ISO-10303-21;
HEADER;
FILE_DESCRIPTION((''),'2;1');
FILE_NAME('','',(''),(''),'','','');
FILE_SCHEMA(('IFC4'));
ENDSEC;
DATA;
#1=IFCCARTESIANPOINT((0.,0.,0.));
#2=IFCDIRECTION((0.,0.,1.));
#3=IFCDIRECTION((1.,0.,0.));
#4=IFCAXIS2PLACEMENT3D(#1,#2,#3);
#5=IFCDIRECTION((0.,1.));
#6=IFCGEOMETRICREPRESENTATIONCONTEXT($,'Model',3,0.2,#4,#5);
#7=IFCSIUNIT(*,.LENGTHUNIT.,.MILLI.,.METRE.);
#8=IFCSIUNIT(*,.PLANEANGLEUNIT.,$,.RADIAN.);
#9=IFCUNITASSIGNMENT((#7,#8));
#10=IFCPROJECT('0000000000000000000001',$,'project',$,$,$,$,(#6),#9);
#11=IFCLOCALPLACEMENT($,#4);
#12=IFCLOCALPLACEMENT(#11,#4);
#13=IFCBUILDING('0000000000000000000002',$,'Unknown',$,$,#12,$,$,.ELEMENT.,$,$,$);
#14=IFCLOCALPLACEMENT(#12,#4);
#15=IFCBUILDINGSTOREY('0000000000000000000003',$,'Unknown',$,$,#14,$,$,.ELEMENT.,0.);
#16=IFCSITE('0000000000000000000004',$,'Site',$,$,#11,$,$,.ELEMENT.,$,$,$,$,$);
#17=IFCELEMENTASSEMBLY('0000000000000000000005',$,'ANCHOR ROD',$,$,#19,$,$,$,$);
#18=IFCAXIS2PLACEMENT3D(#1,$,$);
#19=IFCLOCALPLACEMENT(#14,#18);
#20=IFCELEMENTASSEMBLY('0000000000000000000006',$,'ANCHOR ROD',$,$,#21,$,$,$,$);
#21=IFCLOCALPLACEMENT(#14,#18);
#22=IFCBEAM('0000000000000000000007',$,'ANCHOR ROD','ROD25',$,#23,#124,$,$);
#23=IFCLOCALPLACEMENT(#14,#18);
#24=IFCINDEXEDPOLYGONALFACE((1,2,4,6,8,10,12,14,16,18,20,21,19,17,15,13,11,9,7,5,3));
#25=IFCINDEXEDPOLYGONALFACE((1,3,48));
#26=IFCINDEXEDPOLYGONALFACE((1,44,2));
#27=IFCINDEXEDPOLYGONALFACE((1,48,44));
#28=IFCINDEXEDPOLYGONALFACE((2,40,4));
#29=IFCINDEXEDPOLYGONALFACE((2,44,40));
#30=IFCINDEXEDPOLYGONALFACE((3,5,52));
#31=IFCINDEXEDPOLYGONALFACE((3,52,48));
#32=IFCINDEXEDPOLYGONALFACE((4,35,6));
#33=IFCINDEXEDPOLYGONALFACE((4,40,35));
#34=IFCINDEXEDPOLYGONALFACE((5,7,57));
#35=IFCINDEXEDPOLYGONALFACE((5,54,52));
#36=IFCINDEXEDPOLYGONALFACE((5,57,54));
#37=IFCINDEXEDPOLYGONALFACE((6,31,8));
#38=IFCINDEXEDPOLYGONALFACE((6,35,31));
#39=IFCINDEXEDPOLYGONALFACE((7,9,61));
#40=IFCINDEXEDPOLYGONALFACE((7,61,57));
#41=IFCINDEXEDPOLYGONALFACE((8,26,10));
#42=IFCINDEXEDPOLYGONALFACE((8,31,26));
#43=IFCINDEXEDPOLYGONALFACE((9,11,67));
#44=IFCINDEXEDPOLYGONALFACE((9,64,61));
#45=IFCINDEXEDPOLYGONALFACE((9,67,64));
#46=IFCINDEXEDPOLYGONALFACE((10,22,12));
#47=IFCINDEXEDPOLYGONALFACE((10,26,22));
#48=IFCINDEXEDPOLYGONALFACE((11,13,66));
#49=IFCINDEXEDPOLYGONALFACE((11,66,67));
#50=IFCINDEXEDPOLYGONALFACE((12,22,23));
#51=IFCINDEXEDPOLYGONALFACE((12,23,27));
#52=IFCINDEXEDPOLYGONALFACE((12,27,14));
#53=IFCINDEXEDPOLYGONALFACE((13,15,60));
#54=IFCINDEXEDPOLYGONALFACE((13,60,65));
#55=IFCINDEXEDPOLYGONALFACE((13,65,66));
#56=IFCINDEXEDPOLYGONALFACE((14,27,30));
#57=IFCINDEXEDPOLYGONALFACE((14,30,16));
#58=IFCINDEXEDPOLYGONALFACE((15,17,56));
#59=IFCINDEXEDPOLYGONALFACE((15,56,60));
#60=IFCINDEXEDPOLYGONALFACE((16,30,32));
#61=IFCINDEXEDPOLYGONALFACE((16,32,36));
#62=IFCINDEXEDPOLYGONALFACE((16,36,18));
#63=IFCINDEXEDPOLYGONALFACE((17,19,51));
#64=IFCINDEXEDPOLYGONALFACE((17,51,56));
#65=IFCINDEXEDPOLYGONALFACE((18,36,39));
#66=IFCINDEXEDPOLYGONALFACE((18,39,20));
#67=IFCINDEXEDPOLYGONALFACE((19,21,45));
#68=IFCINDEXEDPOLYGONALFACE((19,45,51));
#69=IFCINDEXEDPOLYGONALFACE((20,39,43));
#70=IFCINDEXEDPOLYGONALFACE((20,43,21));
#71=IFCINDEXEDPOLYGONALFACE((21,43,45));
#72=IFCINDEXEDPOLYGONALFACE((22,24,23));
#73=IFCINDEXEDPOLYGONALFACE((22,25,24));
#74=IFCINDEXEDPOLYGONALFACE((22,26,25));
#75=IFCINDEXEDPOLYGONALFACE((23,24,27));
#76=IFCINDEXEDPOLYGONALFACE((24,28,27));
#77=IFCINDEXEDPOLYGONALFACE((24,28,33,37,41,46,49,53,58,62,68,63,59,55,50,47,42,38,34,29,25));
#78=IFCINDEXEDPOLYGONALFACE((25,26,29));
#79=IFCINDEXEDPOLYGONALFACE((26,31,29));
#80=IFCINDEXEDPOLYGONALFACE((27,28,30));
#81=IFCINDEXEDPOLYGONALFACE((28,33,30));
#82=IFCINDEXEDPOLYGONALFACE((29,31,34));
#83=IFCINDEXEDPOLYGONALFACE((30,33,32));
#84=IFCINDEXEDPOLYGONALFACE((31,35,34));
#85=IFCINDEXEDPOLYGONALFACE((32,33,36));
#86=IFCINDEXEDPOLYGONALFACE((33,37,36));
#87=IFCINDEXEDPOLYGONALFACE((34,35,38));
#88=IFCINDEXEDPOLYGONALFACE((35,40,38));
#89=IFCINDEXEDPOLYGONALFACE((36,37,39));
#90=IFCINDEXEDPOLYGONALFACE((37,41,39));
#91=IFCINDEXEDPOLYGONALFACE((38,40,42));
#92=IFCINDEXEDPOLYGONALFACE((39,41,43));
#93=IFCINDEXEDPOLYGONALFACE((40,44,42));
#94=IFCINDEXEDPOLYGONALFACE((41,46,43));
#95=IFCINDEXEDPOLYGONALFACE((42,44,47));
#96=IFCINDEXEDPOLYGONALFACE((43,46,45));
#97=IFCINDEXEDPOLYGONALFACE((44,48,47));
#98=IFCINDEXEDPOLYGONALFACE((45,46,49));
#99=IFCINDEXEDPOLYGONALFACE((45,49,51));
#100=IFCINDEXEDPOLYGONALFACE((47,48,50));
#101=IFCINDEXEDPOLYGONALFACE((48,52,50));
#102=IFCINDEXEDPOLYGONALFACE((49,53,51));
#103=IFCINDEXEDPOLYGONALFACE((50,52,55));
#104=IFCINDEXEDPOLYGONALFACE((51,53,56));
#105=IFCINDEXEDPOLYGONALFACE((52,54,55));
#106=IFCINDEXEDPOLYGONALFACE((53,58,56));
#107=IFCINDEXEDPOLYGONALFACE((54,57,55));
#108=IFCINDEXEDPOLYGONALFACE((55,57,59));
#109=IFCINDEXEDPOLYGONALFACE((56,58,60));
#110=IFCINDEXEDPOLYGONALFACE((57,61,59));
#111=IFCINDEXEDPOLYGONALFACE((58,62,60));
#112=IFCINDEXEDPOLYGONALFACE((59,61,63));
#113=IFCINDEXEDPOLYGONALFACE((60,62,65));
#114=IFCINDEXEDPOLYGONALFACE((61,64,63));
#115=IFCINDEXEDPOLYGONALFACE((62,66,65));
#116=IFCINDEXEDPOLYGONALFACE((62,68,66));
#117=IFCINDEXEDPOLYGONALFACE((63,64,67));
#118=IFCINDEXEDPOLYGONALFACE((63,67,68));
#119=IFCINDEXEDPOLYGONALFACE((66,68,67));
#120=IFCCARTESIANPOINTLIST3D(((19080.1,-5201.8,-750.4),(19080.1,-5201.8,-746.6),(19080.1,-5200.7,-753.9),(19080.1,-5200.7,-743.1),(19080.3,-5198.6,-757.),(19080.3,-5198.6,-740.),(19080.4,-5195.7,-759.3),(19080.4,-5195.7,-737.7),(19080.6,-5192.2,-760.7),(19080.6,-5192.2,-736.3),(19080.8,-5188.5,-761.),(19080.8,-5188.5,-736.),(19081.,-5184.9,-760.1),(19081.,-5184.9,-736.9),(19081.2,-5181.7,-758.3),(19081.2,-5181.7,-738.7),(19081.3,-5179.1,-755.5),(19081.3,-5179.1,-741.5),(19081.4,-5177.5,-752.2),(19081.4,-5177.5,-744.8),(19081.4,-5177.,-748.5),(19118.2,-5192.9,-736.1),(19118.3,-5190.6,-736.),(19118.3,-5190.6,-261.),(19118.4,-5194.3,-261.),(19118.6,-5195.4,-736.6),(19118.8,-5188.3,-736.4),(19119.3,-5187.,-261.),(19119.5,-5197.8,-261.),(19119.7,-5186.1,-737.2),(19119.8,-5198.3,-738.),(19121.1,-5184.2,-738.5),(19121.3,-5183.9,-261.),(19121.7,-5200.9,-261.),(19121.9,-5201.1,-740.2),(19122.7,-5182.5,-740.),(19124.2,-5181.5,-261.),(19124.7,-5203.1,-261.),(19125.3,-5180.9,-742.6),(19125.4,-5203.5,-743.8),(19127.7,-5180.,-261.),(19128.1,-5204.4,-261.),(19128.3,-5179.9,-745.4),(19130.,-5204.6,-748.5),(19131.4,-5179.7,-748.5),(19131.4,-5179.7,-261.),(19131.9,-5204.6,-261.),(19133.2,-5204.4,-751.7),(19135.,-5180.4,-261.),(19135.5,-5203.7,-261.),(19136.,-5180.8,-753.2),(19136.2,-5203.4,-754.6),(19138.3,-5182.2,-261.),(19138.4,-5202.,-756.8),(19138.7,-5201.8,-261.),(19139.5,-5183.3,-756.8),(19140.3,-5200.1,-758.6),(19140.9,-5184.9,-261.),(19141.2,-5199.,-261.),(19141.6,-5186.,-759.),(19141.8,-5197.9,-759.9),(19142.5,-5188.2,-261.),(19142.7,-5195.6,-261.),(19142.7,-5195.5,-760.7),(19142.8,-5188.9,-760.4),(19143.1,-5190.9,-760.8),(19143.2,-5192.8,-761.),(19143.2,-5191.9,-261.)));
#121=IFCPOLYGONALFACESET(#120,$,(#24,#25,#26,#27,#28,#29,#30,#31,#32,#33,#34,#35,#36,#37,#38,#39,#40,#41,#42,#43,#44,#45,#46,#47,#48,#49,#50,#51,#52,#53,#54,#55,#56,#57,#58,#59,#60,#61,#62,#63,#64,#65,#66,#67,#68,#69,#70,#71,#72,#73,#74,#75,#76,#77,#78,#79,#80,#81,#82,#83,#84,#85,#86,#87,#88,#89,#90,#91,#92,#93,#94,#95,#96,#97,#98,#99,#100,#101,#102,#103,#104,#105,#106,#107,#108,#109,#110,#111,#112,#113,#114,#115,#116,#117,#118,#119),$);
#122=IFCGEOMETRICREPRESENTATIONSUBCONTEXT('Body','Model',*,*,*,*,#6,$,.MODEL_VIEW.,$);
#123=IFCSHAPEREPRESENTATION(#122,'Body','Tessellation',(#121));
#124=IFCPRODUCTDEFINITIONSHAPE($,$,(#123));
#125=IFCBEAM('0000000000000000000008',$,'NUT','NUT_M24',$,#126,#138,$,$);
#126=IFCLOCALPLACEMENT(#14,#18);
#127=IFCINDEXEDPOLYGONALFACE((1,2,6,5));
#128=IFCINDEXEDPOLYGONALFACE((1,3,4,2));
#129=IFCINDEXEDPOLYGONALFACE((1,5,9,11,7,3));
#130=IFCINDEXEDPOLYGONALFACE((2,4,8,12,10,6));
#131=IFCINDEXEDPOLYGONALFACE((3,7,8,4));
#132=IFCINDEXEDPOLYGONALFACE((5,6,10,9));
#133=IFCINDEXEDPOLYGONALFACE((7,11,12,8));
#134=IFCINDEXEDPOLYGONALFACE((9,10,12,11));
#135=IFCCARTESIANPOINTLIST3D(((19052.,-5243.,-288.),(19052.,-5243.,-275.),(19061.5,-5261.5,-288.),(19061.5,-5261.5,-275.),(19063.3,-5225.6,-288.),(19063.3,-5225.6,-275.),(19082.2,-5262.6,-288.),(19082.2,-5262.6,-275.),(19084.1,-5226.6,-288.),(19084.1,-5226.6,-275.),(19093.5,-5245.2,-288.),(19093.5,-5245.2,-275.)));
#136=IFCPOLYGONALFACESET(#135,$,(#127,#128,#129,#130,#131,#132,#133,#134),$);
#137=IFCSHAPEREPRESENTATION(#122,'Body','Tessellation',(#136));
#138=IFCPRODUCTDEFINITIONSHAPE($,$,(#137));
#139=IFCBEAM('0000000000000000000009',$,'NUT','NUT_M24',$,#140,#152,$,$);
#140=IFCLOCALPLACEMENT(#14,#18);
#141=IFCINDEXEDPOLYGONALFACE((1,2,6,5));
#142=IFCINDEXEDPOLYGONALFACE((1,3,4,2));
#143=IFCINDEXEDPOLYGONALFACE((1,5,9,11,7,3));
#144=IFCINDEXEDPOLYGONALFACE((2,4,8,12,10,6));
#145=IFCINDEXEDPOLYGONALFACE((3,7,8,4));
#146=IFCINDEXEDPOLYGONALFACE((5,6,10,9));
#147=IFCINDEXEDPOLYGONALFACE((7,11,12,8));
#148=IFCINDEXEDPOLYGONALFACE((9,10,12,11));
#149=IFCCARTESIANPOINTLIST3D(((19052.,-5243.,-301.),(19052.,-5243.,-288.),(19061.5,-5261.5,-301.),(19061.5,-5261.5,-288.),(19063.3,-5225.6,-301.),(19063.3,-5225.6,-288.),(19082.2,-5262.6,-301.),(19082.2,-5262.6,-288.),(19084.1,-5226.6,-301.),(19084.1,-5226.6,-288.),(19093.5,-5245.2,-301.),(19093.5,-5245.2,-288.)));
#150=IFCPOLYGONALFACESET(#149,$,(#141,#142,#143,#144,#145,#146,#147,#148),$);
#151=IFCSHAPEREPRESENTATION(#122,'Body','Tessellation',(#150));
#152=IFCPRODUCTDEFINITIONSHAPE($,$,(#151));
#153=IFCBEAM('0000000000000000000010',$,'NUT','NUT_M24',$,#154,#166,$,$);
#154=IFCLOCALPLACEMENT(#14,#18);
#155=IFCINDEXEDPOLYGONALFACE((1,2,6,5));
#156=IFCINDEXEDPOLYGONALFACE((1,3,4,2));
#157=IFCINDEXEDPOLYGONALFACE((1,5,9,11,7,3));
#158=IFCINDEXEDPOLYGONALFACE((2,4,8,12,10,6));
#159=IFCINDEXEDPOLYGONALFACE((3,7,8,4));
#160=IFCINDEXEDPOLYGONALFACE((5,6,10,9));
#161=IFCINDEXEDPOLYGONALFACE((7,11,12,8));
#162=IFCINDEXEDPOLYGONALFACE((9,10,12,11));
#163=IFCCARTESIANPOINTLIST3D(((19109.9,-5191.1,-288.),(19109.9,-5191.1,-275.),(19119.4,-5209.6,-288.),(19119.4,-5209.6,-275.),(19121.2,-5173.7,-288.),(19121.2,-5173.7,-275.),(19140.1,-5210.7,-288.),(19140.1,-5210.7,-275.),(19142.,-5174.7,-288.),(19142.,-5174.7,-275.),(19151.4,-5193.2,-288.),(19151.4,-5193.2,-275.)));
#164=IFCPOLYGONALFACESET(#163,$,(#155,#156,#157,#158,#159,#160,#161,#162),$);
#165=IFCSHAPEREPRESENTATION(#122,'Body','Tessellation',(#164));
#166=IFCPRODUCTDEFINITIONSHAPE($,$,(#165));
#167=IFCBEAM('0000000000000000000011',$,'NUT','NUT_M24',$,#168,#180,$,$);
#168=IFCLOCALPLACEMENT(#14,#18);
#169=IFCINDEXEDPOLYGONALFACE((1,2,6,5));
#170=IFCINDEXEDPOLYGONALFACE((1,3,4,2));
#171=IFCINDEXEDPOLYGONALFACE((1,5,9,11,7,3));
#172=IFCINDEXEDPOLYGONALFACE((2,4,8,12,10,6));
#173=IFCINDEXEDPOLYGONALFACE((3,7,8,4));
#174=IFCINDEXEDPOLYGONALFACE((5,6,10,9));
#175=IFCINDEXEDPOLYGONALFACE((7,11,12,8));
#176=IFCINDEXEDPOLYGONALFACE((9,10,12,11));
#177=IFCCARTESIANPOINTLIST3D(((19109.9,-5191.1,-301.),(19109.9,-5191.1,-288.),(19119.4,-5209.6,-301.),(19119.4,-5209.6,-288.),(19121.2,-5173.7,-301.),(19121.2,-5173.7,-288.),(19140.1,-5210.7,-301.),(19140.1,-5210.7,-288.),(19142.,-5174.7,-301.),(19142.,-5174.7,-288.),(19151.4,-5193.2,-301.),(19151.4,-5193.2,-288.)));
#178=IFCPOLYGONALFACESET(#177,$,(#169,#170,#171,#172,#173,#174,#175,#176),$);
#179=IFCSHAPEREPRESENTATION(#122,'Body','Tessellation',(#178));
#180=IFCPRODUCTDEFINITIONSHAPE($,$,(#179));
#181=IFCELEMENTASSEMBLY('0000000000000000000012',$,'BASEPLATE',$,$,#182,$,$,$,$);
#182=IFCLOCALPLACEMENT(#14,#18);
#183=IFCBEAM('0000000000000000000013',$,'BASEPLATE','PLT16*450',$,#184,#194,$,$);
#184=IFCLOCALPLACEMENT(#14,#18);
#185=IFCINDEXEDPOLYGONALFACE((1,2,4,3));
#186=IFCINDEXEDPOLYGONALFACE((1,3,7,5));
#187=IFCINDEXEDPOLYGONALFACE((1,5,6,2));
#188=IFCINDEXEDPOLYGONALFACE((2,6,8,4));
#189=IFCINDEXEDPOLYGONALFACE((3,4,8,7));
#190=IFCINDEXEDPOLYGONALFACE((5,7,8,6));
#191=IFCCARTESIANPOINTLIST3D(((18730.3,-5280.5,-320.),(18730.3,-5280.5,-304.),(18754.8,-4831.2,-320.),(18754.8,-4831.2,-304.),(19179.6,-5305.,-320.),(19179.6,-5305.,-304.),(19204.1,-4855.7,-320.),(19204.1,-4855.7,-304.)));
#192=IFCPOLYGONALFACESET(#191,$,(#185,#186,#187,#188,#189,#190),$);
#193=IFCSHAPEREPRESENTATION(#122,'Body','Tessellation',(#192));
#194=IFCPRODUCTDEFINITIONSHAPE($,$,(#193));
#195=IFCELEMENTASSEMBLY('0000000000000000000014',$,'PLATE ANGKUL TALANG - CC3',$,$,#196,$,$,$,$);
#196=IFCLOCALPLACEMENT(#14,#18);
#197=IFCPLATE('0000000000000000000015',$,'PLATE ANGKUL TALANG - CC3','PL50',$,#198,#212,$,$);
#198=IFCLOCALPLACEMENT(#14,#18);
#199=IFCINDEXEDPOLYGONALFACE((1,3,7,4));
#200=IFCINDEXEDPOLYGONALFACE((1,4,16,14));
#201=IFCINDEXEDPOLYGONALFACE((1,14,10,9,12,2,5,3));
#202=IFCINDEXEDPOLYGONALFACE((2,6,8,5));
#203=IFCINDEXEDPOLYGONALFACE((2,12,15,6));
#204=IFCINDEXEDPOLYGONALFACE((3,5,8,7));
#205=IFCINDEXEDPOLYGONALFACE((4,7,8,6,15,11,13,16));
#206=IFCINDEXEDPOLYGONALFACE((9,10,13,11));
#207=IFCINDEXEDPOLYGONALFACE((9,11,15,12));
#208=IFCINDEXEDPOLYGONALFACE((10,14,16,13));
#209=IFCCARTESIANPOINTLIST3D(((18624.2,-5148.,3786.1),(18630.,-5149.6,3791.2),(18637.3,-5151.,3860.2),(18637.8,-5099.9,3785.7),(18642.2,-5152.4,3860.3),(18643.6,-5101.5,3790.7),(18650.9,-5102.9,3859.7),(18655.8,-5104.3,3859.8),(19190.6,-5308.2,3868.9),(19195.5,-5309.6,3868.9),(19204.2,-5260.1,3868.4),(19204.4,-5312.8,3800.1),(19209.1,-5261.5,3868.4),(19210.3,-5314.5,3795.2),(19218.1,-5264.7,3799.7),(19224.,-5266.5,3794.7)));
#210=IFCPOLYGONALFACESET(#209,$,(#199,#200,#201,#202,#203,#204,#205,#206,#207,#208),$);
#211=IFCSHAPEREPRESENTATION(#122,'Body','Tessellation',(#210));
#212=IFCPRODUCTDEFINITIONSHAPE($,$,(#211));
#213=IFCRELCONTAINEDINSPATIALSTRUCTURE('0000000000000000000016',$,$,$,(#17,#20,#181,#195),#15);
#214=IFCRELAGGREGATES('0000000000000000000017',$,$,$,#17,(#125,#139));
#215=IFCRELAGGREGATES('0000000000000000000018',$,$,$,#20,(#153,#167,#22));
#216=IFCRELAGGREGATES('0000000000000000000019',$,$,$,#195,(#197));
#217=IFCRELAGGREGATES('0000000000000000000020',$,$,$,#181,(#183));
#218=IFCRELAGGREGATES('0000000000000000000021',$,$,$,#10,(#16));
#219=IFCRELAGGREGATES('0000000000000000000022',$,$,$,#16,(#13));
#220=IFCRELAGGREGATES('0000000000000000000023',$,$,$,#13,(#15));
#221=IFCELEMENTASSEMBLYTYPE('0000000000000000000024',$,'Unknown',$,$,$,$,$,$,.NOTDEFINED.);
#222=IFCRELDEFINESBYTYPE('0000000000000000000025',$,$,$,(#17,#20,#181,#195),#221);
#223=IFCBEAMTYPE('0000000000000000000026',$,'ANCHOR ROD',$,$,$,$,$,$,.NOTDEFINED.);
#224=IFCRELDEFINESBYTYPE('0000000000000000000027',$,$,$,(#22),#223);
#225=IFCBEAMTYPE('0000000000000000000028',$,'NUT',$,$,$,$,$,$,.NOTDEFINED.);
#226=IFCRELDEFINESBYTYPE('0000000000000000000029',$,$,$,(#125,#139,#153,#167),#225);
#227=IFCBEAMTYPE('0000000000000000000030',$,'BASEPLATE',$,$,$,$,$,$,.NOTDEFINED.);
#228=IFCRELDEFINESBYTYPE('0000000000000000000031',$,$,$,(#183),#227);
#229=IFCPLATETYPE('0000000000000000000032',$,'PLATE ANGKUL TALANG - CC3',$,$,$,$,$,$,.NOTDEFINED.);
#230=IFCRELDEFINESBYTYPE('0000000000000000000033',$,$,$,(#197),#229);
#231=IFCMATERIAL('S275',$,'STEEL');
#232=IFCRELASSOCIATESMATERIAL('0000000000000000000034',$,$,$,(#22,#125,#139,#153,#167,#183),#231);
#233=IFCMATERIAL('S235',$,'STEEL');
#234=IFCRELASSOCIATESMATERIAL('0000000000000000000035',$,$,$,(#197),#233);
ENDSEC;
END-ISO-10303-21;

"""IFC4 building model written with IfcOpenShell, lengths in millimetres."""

from ifc_helpers import new_model, entity, si_unit, direction, frame, origin_with_axes, origin_2d_with_axis, place, context, subcontext, project, spatial, polyline, line, indexed_curve, rectangle, outline, extrude, material, material_profile, profile_set, profile_usage, type_object, element, aggregate, save


model = new_model("IFC4")

# Units and contexts
model_context = context("Model", 3, precision=0.2, world=origin_with_axes(), true_north=direction((0.0, 1.0)))
body_context = subcontext(model_context, "Body", "Model", "MODEL_VIEW")
ifc_project = project(units=[si_unit("LENGTHUNIT", "METRE", prefix="MILLI"), si_unit("PLANEANGLEUNIT", "RADIAN")], contexts=[model_context])

# Site, building, storey
site_placement = place(None, origin_with_axes())
site = spatial("IfcSite", under=ifc_project, at=site_placement, Name="Site", CompositionType="ELEMENT")
building_placement = place(site_placement, origin_with_axes())
building = spatial("IfcBuilding", under=site, at=building_placement, Name="Unknown", CompositionType="ELEMENT")
storey_placement = place(building_placement, origin_with_axes())
storey = spatial("IfcBuildingStorey", under=building, at=storey_placement, Name="Unknown", CompositionType="ELEMENT", Elevation=0.0)

# Element assemblies
element_assembly_type = type_object("IfcElementAssemblyType", Name="Unknown", PredefinedType="NOTDEFINED")
ifc_material_1 = material(Name="S235", Category="STEEL")
assembly_1_placement = place(storey_placement, frame((19072.8, -5244.1, -261.0), z_axis=(0.054389, 0.99852, 0.0), x_axis=(0.0, 0.0, -1.0)))
assembly_1 = element("IfcElementAssembly", 1, at=assembly_1_placement, inside=storey, type_object=element_assembly_type, Name="ANCHOR ROD")
ifc_material_2 = material(Name="S275", Category="STEEL")
assembly_2_placement = place(storey_placement, frame((19130.7, -5192.2, -261.0), z_axis=(0.054389, 0.99852, 0.0), x_axis=(0.0, 0.0, -1.0)))
assembly_2 = element("IfcElementAssembly", 2, at=assembly_2_placement, inside=storey, type_object=element_assembly_type, Name="ANCHOR ROD")

# Beams
beam_type_1 = type_object("IfcBeamType", Name="ANCHOR ROD", PredefinedType="NOTDEFINED")
beam_1_placement = place(assembly_2_placement, origin_with_axes())
beam_1 = element("IfcBeam", 3, at=beam_1_placement, type_object=beam_type_1, material=ifc_material_2, Name="ANCHOR ROD", Description="ROD25", context=body_context, shape_type="SolidModel", body=[
    entity("IfcSweptDiskSolid", entity("IfcIndexedPolyCurve", entity("IfcCartesianPointList3D", [[0.0, 0.0, 0.0], [487.5, 0.0, 0.0], [487.5, 50.0, 0.0]]), [entity("IfcLineIndex", [1, 2, 3])]), 12.5),
])
ifc_material_profile_1 = material_profile(ifc_material_2, outline(polyline([(18.0, 10.4), (0.0, 20.8), (-18.0, 10.4), (-18.0, -10.4), (0.0, -20.8), (18.0, -10.4), (18.0, 10.4)])), Name="NUT_M24")
ifc_profile_set_1 = profile_set([ifc_material_profile_1])
ifc_profile_usage_1 = profile_usage(ifc_profile_set_1, cardinal=5)
beam_type_2 = type_object("IfcBeamType", Name="NUT", PredefinedType="NOTDEFINED")
beam_2_placement = place(assembly_1_placement, frame((14.0, 0.0, 0.0), z_axis=(0.0, 0.003456, 0.999994), x_axis=(1.0, 0.0, 0.0)))
beam_2 = element("IfcBeam", 4, at=beam_2_placement, type_object=beam_type_2, material=ifc_profile_usage_1, Name="NUT", Description="NUT_M24", context=body_context, shape_type="SolidModel", body=[
    extrude(outline(polyline([(18.0, 10.4), (0.0, 20.8), (-18.0, 10.4), (-18.0, -10.4), (0.0, -20.8), (18.0, -10.4), (18.0, 10.4)])), frame((0.0, 0.0, 0.0), z_axis=(-1.0, 0.0, 0.0), x_axis=(0.0, 0.0, 1.0)), (0.0, 0.0, -1.0), 13.0),
])
beam_3_placement = place(assembly_1_placement, frame((27.0, 0.0, 0.0), z_axis=(0.0, 0.003456, 0.999994), x_axis=(1.0, 0.0, 0.0)))
beam_3 = element("IfcBeam", 5, at=beam_3_placement, type_object=beam_type_2, material=ifc_profile_usage_1, Name="NUT", Description="NUT_M24", context=body_context, shape_type="SolidModel", body=[
    extrude(outline(polyline([(18.0, 10.4), (0.0, 20.8), (-18.0, 10.4), (-18.0, -10.4), (0.0, -20.8), (18.0, -10.4), (18.0, 10.4)])), frame((0.0, 0.0, 0.0), z_axis=(-1.0, 0.0, 0.0), x_axis=(0.0, 0.0, 1.0)), (0.0, 0.0, -1.0), 13.0),
])
aggregate(assembly_1, [beam_2, beam_3])
beam_4_placement = place(assembly_2_placement, frame((14.0, 0.0, 0.0), z_axis=(0.0, 0.003456, 0.999994), x_axis=(1.0, 0.0, 0.0)))
beam_4 = element("IfcBeam", 6, at=beam_4_placement, type_object=beam_type_2, material=ifc_profile_usage_1, Name="NUT", Description="NUT_M24", context=body_context, shape_type="SolidModel", body=[
    extrude(outline(polyline([(18.0, 10.4), (0.0, 20.8), (-18.0, 10.4), (-18.0, -10.4), (0.0, -20.8), (18.0, -10.4), (18.0, 10.4)])), frame((0.0, 0.0, 0.0), z_axis=(-1.0, 0.0, 0.0), x_axis=(0.0, 0.0, 1.0)), (0.0, 0.0, -1.0), 13.0),
])
beam_5_placement = place(assembly_2_placement, frame((27.0, 0.0, 0.0), z_axis=(0.0, 0.003456, 0.999994), x_axis=(1.0, 0.0, 0.0)))
beam_5 = element("IfcBeam", 7, at=beam_5_placement, type_object=beam_type_2, material=ifc_profile_usage_1, Name="NUT", Description="NUT_M24", context=body_context, shape_type="SolidModel", body=[
    extrude(outline(polyline([(18.0, 10.4), (0.0, 20.8), (-18.0, 10.4), (-18.0, -10.4), (0.0, -20.8), (18.0, -10.4), (18.0, 10.4)])), frame((0.0, 0.0, 0.0), z_axis=(-1.0, 0.0, 0.0), x_axis=(0.0, 0.0, 1.0)), (0.0, 0.0, -1.0), 13.0),
])
aggregate(assembly_2, [beam_4, beam_5, beam_1])

# Element assembly, beam
assembly_3_placement = place(storey_placement, frame((19191.9, -5080.3, -312.0), z_axis=(0.0, 0.0, 1.0), x_axis=(-0.99852, 0.054389, 0.0)))
assembly_3 = element("IfcElementAssembly", 8, at=assembly_3_placement, inside=storey, type_object=element_assembly_type, Name="BASEPLATE")
ifc_material_profile_2 = material_profile(ifc_material_2, rectangle(XDim=16.0, YDim=450.0, at=origin_2d_with_axis()), Name="PLT16*450")
ifc_profile_set_2 = profile_set([ifc_material_profile_2])
ifc_profile_usage_2 = profile_usage(ifc_profile_set_2, cardinal=8)
beam_type_3 = type_object("IfcBeamType", Name="BASEPLATE", PredefinedType="NOTDEFINED")
beam_6_placement = place(assembly_3_placement, origin_with_axes())
beam_6 = element("IfcBeam", 9, at=beam_6_placement, type_object=beam_type_3, material=ifc_profile_usage_2, Name="BASEPLATE", Description="PLT16*450", context=body_context, shape_type="SolidModel", body=[
    extrude(rectangle(XDim=16.0, YDim=450.0, at=origin_2d_with_axis()), frame((0.0, 0.0, 0.0), z_axis=(-1.0, 0.0, 0.0), x_axis=(0.0, 0.0, 1.0)), (0.0, 0.0, -1.0), 450.0),
])

# Element assembly, plate
assembly_4_placement = place(storey_placement, frame((19202.3, -5285.5, 3868.7), z_axis=(0.273424, 0.961845, -0.009721), x_axis=(0.196778, -0.065825, -0.978236)))
assembly_4 = element("IfcElementAssembly", 10, at=assembly_4_placement, inside=storey, type_object=element_assembly_type, Name="PLATE ANGKUL TALANG - CC3")
ifc_material_profile_3 = material_profile(ifc_material_1, outline(indexed_curve([(0.0, 0.0), (75.4, 0.0), (-42.1, 598.0), (-111.8, 569.5), (-110.8, 564.5), (-45.8, 591.0), (69.3, 5.0), (-1.0, 5.0)], segments=[line(1, 2, 3, 4, 5, 6, 7, 8, 1)])), Name="PL50")
ifc_profile_set_3 = profile_set([ifc_material_profile_3])
ifc_profile_usage_3 = profile_usage(ifc_profile_set_3, cardinal=5)
plate_type_1 = type_object("IfcPlateType", Name="PLATE ANGKUL TALANG - CC3", PredefinedType="NOTDEFINED")
plate_1_placement = place(assembly_4_placement, origin_with_axes())
plate_1 = element("IfcPlate", 11, at=plate_1_placement, type_object=plate_type_1, material=ifc_profile_usage_3, Name="PLATE ANGKUL TALANG - CC3", Description="PL50", context=body_context, shape_type="SolidModel", body=[
    extrude(outline(indexed_curve([(0.0, 0.0), (75.4, 0.0), (-42.1, 598.0), (-111.8, 569.5), (-110.8, 564.5), (-45.8, 591.0), (69.3, 5.0), (-1.0, 5.0)], segments=[line(1, 2, 3, 4, 5, 6, 7, 8, 1)])), frame((0.0, 0.0, 25.0), z_axis=(0.0, 0.0, 1.0), x_axis=(1.0, 0.0, 0.0)), (0.0, 0.0, -1.0), 50.0),
])
aggregate(assembly_4, [plate_1])

aggregate(assembly_3, [beam_6])

save(model, "model.ifc")
